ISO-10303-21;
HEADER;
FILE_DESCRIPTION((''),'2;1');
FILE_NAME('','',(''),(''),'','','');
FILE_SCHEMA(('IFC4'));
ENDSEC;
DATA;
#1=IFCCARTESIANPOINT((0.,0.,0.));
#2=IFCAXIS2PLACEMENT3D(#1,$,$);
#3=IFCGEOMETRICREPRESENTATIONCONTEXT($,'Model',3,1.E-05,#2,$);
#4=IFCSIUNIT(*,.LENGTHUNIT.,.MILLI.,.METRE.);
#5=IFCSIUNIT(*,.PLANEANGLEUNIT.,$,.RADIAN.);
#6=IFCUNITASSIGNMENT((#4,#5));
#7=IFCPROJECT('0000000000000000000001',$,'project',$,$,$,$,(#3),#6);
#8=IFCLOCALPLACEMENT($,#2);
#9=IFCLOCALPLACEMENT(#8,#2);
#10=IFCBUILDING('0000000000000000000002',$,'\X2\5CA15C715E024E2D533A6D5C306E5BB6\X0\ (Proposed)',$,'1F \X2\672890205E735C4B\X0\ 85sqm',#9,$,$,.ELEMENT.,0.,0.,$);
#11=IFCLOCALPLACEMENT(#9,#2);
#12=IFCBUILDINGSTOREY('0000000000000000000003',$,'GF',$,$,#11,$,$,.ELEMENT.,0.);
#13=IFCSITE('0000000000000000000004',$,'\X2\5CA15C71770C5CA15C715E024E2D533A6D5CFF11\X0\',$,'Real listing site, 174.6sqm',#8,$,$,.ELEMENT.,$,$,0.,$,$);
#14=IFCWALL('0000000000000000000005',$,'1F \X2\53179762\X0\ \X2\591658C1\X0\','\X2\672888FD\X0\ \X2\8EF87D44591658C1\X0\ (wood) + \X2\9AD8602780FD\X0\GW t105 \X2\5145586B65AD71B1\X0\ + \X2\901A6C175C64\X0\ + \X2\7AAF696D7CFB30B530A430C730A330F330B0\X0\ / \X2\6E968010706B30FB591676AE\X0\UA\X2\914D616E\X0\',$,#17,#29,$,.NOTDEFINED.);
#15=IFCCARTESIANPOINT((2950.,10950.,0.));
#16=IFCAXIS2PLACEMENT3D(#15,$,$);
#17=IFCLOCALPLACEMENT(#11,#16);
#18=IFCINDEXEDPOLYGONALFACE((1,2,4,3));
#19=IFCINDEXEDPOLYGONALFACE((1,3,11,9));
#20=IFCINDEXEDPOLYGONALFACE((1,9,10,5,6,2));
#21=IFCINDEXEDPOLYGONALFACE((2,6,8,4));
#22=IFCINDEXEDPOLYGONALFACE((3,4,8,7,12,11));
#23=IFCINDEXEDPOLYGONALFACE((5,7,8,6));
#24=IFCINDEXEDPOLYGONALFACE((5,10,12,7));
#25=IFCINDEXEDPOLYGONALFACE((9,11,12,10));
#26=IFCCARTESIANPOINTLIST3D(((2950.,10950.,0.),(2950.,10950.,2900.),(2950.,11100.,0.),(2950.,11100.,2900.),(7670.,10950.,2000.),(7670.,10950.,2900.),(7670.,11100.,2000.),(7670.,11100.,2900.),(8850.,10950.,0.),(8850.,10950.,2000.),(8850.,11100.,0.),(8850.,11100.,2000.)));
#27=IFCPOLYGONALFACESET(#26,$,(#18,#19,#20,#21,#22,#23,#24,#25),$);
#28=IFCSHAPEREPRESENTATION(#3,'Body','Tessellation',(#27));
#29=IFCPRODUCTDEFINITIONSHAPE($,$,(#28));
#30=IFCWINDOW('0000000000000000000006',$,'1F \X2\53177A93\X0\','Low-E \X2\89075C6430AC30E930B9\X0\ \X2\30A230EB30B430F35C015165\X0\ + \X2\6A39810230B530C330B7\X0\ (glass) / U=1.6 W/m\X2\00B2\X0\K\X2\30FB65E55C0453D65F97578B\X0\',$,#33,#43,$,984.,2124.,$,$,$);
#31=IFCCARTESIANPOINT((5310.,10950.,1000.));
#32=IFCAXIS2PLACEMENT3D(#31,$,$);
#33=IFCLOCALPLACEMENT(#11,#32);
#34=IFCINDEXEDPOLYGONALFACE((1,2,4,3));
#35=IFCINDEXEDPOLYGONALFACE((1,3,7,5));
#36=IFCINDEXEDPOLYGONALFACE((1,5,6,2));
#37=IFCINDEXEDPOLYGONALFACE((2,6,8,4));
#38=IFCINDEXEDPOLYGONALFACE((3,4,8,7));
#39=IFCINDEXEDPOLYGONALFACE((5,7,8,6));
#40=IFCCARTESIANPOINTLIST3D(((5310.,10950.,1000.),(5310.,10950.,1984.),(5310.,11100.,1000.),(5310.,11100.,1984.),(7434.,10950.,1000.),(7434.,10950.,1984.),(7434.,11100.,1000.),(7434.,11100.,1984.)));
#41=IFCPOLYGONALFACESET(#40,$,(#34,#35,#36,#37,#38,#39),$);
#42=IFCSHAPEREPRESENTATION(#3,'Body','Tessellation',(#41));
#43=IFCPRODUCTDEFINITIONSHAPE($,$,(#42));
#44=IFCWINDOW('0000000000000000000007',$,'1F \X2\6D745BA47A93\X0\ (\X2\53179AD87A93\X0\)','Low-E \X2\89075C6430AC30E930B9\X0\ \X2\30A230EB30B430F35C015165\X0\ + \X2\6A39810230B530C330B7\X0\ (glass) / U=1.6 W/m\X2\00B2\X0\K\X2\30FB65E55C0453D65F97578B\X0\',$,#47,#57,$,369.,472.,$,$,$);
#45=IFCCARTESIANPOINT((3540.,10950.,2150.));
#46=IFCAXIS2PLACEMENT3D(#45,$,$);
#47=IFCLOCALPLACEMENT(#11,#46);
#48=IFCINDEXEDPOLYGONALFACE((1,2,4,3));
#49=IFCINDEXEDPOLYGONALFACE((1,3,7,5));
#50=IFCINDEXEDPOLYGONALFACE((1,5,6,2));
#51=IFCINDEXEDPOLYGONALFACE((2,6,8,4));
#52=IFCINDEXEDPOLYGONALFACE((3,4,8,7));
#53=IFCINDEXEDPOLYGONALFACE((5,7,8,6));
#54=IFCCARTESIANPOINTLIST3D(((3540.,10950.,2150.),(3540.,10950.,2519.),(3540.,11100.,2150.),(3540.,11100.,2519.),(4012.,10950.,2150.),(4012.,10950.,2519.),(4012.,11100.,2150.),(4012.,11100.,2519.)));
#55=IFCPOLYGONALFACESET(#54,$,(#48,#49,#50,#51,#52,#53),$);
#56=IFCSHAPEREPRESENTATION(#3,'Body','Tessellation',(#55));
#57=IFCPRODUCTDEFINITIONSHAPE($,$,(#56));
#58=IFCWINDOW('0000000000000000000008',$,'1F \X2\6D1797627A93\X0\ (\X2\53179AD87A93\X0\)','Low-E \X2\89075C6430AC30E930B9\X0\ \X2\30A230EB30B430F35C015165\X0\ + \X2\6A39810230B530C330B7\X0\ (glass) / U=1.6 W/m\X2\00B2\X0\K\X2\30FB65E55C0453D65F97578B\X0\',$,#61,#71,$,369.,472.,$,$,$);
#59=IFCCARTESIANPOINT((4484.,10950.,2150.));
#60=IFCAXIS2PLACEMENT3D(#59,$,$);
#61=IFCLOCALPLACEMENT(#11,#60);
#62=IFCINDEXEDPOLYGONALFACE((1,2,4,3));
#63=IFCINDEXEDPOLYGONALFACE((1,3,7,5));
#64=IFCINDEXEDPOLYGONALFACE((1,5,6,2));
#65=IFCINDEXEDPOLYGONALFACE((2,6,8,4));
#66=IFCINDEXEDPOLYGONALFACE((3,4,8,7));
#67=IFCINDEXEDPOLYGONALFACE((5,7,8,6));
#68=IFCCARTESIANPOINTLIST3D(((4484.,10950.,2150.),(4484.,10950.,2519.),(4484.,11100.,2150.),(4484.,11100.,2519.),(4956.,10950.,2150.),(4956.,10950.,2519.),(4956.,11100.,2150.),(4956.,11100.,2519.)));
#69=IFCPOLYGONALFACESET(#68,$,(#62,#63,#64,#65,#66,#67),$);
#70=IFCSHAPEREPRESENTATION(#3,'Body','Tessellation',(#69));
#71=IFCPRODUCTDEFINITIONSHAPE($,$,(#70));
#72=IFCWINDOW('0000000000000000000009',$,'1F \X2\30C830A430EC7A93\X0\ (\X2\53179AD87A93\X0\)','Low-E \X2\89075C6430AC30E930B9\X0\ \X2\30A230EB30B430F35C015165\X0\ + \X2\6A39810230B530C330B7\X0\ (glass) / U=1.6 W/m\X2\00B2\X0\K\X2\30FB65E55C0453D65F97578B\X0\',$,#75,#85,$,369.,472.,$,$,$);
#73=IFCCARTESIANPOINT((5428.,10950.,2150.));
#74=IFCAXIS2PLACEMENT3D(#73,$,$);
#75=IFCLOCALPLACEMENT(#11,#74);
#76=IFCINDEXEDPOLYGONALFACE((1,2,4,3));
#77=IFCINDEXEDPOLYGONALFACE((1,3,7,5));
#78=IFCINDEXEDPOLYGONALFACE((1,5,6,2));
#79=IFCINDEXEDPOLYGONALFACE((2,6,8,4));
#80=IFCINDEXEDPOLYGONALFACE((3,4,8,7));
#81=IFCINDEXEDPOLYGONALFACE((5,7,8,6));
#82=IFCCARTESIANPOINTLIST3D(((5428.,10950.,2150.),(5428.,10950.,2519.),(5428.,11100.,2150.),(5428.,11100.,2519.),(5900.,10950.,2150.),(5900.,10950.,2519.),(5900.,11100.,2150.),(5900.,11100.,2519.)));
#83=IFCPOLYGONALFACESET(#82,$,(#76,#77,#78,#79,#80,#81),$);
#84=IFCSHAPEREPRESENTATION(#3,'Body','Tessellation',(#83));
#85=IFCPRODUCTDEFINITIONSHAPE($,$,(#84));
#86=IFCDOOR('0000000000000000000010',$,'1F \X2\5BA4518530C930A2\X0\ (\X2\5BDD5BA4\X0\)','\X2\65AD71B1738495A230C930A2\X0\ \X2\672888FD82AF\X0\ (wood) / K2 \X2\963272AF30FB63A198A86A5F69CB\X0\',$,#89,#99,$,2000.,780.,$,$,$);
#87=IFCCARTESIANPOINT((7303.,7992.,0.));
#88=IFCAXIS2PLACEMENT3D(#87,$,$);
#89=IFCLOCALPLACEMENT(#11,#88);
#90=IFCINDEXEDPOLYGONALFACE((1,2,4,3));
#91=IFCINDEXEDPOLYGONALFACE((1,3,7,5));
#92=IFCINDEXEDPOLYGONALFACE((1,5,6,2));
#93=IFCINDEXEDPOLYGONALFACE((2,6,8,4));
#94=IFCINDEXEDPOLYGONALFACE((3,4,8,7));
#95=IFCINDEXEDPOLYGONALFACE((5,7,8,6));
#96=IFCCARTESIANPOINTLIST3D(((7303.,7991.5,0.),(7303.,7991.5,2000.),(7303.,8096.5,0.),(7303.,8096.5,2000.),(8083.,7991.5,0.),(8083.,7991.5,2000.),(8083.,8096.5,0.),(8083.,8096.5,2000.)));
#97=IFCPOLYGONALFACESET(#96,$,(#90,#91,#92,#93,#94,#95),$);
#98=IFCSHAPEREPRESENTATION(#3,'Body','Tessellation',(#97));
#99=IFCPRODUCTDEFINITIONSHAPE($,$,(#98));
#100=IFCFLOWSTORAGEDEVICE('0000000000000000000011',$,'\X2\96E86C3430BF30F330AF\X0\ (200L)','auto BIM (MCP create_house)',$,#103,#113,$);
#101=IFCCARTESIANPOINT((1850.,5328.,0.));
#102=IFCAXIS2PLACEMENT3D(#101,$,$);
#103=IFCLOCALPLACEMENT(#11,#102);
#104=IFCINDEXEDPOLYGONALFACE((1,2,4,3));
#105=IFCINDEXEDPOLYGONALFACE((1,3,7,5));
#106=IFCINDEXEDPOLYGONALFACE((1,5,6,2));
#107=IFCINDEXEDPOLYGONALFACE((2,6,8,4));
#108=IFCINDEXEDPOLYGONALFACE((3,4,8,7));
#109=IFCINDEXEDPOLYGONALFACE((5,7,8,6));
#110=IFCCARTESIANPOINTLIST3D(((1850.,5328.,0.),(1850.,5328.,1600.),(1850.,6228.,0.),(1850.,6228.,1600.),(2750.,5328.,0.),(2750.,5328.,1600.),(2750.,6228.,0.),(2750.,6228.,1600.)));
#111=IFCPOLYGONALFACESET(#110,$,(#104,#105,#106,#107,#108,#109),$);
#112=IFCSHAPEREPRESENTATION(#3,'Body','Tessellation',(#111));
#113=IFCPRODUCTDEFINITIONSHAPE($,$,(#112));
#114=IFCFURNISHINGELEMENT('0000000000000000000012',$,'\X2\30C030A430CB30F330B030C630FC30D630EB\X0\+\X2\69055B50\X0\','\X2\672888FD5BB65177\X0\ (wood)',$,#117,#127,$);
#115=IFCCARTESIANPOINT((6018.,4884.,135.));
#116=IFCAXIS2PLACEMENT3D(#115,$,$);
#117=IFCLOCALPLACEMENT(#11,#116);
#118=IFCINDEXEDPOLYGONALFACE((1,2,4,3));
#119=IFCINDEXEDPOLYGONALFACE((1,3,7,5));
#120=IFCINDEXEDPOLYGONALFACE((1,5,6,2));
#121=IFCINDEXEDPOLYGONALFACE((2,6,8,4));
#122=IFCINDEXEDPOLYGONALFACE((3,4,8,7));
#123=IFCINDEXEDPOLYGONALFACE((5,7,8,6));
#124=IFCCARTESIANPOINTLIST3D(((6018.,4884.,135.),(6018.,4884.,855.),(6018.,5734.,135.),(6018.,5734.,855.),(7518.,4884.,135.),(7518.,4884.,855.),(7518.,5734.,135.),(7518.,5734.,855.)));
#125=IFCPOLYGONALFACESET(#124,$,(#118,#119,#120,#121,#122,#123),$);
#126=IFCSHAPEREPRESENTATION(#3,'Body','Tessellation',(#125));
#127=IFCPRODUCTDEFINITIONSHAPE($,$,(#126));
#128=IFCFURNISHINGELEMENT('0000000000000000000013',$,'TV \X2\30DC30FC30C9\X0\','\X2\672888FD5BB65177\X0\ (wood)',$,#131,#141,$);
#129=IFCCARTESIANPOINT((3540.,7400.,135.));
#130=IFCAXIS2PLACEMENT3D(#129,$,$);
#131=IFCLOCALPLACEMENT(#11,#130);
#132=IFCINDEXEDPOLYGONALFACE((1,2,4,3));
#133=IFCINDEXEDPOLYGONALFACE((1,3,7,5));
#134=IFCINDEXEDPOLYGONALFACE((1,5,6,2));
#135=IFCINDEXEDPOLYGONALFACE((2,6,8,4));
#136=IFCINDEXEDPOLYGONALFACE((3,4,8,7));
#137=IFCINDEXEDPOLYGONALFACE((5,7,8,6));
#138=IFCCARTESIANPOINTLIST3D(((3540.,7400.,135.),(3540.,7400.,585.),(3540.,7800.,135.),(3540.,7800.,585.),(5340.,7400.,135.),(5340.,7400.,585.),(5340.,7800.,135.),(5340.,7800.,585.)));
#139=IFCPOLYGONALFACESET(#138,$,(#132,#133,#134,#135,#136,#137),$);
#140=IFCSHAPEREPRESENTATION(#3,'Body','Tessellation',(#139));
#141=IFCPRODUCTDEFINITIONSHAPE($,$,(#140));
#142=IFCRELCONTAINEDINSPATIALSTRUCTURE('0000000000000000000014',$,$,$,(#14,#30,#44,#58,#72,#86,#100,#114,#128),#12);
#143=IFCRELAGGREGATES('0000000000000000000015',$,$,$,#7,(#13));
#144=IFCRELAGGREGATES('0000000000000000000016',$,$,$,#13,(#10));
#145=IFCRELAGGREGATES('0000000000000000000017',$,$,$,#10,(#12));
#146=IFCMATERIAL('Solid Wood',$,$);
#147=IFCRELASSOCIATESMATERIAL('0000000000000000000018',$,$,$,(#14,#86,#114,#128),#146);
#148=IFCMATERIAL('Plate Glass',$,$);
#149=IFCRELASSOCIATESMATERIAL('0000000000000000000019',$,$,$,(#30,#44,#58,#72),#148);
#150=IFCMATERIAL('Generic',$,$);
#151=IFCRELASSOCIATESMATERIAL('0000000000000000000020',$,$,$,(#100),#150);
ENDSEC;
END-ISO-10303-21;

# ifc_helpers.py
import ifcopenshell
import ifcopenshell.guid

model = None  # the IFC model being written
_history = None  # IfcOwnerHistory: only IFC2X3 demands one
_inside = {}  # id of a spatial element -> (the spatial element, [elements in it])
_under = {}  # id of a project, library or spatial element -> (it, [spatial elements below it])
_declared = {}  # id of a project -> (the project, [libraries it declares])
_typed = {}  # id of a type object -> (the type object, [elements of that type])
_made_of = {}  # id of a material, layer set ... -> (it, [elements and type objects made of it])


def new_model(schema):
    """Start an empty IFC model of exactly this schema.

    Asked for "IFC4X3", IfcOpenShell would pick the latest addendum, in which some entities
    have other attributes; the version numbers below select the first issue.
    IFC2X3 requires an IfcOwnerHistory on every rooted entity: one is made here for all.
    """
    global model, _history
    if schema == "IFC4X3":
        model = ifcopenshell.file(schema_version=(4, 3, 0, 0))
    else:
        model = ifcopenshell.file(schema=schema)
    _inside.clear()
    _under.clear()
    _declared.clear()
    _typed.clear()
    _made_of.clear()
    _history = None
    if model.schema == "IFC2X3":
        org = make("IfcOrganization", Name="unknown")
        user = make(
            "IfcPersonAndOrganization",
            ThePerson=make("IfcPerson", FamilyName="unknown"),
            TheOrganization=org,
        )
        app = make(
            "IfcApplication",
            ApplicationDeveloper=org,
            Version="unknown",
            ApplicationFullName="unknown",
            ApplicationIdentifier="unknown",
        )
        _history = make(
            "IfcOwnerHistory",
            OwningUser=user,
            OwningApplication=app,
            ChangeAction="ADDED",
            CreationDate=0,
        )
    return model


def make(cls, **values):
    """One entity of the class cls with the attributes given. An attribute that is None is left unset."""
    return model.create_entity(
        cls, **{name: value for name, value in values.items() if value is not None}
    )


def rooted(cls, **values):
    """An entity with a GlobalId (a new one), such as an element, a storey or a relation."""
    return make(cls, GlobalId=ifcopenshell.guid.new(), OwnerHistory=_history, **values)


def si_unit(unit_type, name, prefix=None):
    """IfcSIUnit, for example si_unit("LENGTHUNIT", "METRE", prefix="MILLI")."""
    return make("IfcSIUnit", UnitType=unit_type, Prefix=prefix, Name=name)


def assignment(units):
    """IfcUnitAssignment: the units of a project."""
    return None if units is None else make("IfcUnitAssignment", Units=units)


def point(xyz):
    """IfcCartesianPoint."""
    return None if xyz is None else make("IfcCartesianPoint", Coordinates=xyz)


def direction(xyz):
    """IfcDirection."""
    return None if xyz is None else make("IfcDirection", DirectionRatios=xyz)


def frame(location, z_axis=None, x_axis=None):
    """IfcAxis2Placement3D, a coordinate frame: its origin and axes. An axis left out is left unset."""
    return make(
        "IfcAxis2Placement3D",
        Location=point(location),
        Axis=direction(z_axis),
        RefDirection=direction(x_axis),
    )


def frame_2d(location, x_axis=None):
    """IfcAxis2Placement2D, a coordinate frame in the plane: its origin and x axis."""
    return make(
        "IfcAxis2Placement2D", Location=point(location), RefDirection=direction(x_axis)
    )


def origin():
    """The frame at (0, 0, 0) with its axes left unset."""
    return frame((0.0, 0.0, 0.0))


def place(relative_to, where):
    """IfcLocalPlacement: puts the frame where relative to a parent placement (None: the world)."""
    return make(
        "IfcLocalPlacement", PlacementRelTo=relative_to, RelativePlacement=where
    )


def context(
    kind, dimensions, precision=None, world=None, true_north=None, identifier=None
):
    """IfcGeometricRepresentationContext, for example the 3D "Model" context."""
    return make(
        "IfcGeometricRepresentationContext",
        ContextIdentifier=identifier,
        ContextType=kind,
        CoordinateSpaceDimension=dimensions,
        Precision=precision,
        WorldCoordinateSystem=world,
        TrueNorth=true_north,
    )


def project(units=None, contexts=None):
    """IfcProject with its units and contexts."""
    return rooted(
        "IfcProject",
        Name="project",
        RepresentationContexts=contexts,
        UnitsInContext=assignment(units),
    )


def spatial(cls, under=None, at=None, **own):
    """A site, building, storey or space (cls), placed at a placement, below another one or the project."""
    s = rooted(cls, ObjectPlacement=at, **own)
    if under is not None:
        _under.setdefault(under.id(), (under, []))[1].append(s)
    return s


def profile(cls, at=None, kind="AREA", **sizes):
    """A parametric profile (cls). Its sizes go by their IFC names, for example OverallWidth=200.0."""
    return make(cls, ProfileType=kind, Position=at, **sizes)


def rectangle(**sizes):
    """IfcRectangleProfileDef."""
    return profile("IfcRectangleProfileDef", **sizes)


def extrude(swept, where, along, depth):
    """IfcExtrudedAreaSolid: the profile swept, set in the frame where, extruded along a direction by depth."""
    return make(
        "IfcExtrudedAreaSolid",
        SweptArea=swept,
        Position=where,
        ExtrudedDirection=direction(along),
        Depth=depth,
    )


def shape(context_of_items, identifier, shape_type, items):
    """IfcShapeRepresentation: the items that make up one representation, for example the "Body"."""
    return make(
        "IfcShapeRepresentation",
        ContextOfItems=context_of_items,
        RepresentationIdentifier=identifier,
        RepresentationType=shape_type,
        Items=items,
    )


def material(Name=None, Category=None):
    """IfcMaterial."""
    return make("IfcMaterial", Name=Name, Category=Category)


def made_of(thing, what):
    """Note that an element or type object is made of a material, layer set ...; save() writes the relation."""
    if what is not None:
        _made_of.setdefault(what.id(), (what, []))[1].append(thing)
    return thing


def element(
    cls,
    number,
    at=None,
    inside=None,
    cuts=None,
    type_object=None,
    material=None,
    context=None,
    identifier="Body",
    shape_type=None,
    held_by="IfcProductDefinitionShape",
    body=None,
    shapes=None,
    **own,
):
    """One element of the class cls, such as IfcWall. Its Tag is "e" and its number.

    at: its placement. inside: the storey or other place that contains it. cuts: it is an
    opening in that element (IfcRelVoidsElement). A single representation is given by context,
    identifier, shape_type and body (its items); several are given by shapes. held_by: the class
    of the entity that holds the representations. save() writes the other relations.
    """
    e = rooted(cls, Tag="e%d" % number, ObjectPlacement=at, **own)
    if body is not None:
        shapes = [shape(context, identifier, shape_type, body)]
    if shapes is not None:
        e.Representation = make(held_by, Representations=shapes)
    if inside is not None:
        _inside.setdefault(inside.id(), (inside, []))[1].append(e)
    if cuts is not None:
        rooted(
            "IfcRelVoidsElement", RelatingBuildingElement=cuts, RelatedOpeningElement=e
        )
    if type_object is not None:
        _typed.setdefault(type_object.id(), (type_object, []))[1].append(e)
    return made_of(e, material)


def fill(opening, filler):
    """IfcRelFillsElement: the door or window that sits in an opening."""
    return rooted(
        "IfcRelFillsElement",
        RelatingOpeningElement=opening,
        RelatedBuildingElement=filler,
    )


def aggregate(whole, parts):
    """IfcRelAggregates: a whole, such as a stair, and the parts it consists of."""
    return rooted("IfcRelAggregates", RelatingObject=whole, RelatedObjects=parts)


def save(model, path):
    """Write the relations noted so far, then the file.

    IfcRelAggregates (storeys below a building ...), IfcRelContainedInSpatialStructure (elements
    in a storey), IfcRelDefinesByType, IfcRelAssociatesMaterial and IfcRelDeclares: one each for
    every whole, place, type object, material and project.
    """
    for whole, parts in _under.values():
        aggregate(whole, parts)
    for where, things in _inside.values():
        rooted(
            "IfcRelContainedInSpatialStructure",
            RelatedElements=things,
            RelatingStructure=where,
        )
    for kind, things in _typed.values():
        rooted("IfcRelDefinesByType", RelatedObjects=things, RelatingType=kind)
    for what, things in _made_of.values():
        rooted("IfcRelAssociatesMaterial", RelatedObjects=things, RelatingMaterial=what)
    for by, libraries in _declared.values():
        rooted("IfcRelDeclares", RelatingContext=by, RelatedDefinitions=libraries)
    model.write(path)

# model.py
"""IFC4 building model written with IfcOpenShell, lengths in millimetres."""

from ifc_helpers import new_model, si_unit, frame, frame_2d, origin, place, context, project, spatial, rectangle, extrude, material, element, fill, save


model = new_model("IFC4")

# Units and contexts
model_context = context("Model", 3, precision=1e-05, world=origin())
ifc_project = project(units=[si_unit("LENGTHUNIT", "METRE", prefix="MILLI"), si_unit("PLANEANGLEUNIT", "RADIAN")], contexts=[model_context])

# Site, building, storey
site_placement = place(None, origin())
site = spatial("IfcSite", under=ifc_project, at=site_placement, Name="岡山県岡山市中区浜１", ObjectType="Real listing site, 174.6sqm", CompositionType="ELEMENT", RefElevation=0.0)
building_placement = place(site_placement, origin())
building = spatial("IfcBuilding", under=site, at=building_placement, Name="岡山市中区浜の家 (Proposed)", ObjectType="1F 木造平屋 85sqm", CompositionType="ELEMENT", ElevationOfRefHeight=0.0, ElevationOfTerrain=0.0)
storey_placement = place(building_placement, origin())
storey = spatial("IfcBuildingStorey", under=building, at=storey_placement, Name="GF", CompositionType="ELEMENT", Elevation=0.0)

# Wall, openings, windows
ifc_material_1 = material(Name="Solid Wood")
wall_1_placement = place(storey_placement, frame((2950.0, 10950.0, 0.0)))
wall_1 = element("IfcWall", 1, at=wall_1_placement, inside=storey, material=ifc_material_1, Name="1F 北面 外壁", Description="木製 軸組外壁 (wood) + 高性能GW t105 充填断熱 + 通気層 + 窯業系サイディング / 準耐火・外皮UA配慮", PredefinedType="NOTDEFINED", context=model_context, shape_type="SweptSolid", body=[
    extrude(rectangle(XDim=5900.0, YDim=150.0, at=frame_2d((2950.0, 75.0))), frame((2950.0, 10950.0, 0.0)), (0.0, 0.0, 1.0), 2900.0),
])
opening_1_placement = place(storey_placement, frame((5310.0, 10950.0, 1000.0)))
opening_1 = element("IfcOpeningElement", 2, at=opening_1_placement, cuts=wall_1, PredefinedType="NOTDEFINED", context=model_context, shape_type="SweptSolid", body=[
    extrude(rectangle(XDim=2124.0, YDim=150.0, at=frame_2d((1062.0, 75.0))), frame((5310.0, 10950.0, 1000.0)), (0.0, 0.0, 1.0), 984.0),
])
opening_2_placement = place(storey_placement, frame((3540.0, 10950.0, 2150.0)))
opening_2 = element("IfcOpeningElement", 3, at=opening_2_placement, cuts=wall_1, PredefinedType="NOTDEFINED", context=model_context, shape_type="SweptSolid", body=[
    extrude(rectangle(XDim=472.0, YDim=150.0, at=frame_2d((236.0, 75.0))), frame((3540.0, 10950.0, 2150.0)), (0.0, 0.0, 1.0), 369.0),
])
opening_3_placement = place(storey_placement, frame((4484.0, 10950.0, 2150.0)))
opening_3 = element("IfcOpeningElement", 4, at=opening_3_placement, cuts=wall_1, PredefinedType="NOTDEFINED", context=model_context, shape_type="SweptSolid", body=[
    extrude(rectangle(XDim=472.0, YDim=150.0, at=frame_2d((236.0, 75.0))), frame((4484.0, 10950.0, 2150.0)), (0.0, 0.0, 1.0), 369.0),
])
opening_4_placement = place(storey_placement, frame((5428.0, 10950.0, 2150.0)))
opening_4 = element("IfcOpeningElement", 5, at=opening_4_placement, cuts=wall_1, PredefinedType="NOTDEFINED", context=model_context, shape_type="SweptSolid", body=[
    extrude(rectangle(XDim=472.0, YDim=150.0, at=frame_2d((236.0, 75.0))), frame((5428.0, 10950.0, 2150.0)), (0.0, 0.0, 1.0), 369.0),
])
ifc_material_2 = material(Name="Plate Glass")
window_1_placement = place(storey_placement, frame((5310.0, 10950.0, 1000.0)))
window_1 = element("IfcWindow", 6, at=window_1_placement, inside=storey, material=ifc_material_2, Name="1F 北窓", Description="Low-E 複層ガラス アルゴン封入 + 樹脂サッシ (glass) / U=1.6 W/m²K・日射取得型", OverallHeight=984.0, OverallWidth=2124.0, context=model_context, shape_type="SweptSolid", body=[
    extrude(rectangle(XDim=2124.0, YDim=150.0, at=frame_2d((1062.0, 75.0))), frame((5310.0, 10950.0, 1000.0)), (0.0, 0.0, 1.0), 984.0),
])
fill(opening_1, window_1)
window_2_placement = place(storey_placement, frame((3540.0, 10950.0, 2150.0)))
window_2 = element("IfcWindow", 7, at=window_2_placement, inside=storey, material=ifc_material_2, Name="1F 浴室窓 (北高窓)", Description="Low-E 複層ガラス アルゴン封入 + 樹脂サッシ (glass) / U=1.6 W/m²K・日射取得型", OverallHeight=369.0, OverallWidth=472.0, context=model_context, shape_type="SweptSolid", body=[
    extrude(rectangle(XDim=472.0, YDim=150.0, at=frame_2d((236.0, 75.0))), frame((3540.0, 10950.0, 2150.0)), (0.0, 0.0, 1.0), 369.0),
])
fill(opening_2, window_2)
window_3_placement = place(storey_placement, frame((4484.0, 10950.0, 2150.0)))
window_3 = element("IfcWindow", 8, at=window_3_placement, inside=storey, material=ifc_material_2, Name="1F 洗面窓 (北高窓)", Description="Low-E 複層ガラス アルゴン封入 + 樹脂サッシ (glass) / U=1.6 W/m²K・日射取得型", OverallHeight=369.0, OverallWidth=472.0, context=model_context, shape_type="SweptSolid", body=[
    extrude(rectangle(XDim=472.0, YDim=150.0, at=frame_2d((236.0, 75.0))), frame((4484.0, 10950.0, 2150.0)), (0.0, 0.0, 1.0), 369.0),
])
fill(opening_3, window_3)
window_4_placement = place(storey_placement, frame((5428.0, 10950.0, 2150.0)))
window_4 = element("IfcWindow", 9, at=window_4_placement, inside=storey, material=ifc_material_2, Name="1F トイレ窓 (北高窓)", Description="Low-E 複層ガラス アルゴン封入 + 樹脂サッシ (glass) / U=1.6 W/m²K・日射取得型", OverallHeight=369.0, OverallWidth=472.0, context=model_context, shape_type="SweptSolid", body=[
    extrude(rectangle(XDim=472.0, YDim=150.0, at=frame_2d((236.0, 75.0))), frame((5428.0, 10950.0, 2150.0)), (0.0, 0.0, 1.0), 369.0),
])
fill(opening_4, window_4)

# Door
door_1_placement = place(storey_placement, frame((7303.0, 7992.0, 0.0)))
element("IfcDoor", 10, at=door_1_placement, inside=storey, material=ifc_material_1, Name="1F 室内ドア (寝室)", Description="断熱玄関ドア 木製芯 (wood) / K2 防犯・採風機構", OverallHeight=2000.0, OverallWidth=780.0, context=model_context, shape_type="SweptSolid", body=[
    extrude(rectangle(XDim=780.0, YDim=105.0, at=frame_2d((390.0, 52.0))), frame((7303.0, 7992.0, 0.0)), (0.0, 0.0, 1.0), 2000.0),
])

# Flow storage device
ifc_material_3 = material(Name="Generic")
flow_storage_device_placement = place(storey_placement, frame((1850.0, 5328.0, 0.0)))
element("IfcFlowStorageDevice", 11, at=flow_storage_device_placement, inside=storey, material=ifc_material_3, Name="雨水タンク (200L)", Description="auto BIM (MCP create_house)", context=model_context, shape_type="SweptSolid", body=[
    extrude(rectangle(XDim=900.0, YDim=900.0, at=frame_2d((450.0, 450.0))), frame((1850.0, 5328.0, 0.0)), (0.0, 0.0, 1.0), 1600.0),
])

# Furnishing elements
furnishing_1_placement = place(storey_placement, frame((6018.0, 4884.0, 135.0)))
element("IfcFurnishingElement", 12, at=furnishing_1_placement, inside=storey, material=ifc_material_1, Name="ダイニングテーブル+椅子", Description="木製家具 (wood)", context=model_context, shape_type="SweptSolid", body=[
    extrude(rectangle(XDim=1500.0, YDim=850.0, at=frame_2d((750.0, 425.0))), frame((6018.0, 4884.0, 135.0)), (0.0, 0.0, 1.0), 720.0),
])
furnishing_2_placement = place(storey_placement, frame((3540.0, 7400.0, 135.0)))
element("IfcFurnishingElement", 13, at=furnishing_2_placement, inside=storey, material=ifc_material_1, Name="TV ボード", Description="木製家具 (wood)", context=model_context, shape_type="SweptSolid", body=[
    extrude(rectangle(XDim=1800.0, YDim=400.0, at=frame_2d((900.0, 200.0))), frame((3540.0, 7400.0, 135.0)), (0.0, 0.0, 1.0), 450.0),
])

save(model, "model.ifc")
